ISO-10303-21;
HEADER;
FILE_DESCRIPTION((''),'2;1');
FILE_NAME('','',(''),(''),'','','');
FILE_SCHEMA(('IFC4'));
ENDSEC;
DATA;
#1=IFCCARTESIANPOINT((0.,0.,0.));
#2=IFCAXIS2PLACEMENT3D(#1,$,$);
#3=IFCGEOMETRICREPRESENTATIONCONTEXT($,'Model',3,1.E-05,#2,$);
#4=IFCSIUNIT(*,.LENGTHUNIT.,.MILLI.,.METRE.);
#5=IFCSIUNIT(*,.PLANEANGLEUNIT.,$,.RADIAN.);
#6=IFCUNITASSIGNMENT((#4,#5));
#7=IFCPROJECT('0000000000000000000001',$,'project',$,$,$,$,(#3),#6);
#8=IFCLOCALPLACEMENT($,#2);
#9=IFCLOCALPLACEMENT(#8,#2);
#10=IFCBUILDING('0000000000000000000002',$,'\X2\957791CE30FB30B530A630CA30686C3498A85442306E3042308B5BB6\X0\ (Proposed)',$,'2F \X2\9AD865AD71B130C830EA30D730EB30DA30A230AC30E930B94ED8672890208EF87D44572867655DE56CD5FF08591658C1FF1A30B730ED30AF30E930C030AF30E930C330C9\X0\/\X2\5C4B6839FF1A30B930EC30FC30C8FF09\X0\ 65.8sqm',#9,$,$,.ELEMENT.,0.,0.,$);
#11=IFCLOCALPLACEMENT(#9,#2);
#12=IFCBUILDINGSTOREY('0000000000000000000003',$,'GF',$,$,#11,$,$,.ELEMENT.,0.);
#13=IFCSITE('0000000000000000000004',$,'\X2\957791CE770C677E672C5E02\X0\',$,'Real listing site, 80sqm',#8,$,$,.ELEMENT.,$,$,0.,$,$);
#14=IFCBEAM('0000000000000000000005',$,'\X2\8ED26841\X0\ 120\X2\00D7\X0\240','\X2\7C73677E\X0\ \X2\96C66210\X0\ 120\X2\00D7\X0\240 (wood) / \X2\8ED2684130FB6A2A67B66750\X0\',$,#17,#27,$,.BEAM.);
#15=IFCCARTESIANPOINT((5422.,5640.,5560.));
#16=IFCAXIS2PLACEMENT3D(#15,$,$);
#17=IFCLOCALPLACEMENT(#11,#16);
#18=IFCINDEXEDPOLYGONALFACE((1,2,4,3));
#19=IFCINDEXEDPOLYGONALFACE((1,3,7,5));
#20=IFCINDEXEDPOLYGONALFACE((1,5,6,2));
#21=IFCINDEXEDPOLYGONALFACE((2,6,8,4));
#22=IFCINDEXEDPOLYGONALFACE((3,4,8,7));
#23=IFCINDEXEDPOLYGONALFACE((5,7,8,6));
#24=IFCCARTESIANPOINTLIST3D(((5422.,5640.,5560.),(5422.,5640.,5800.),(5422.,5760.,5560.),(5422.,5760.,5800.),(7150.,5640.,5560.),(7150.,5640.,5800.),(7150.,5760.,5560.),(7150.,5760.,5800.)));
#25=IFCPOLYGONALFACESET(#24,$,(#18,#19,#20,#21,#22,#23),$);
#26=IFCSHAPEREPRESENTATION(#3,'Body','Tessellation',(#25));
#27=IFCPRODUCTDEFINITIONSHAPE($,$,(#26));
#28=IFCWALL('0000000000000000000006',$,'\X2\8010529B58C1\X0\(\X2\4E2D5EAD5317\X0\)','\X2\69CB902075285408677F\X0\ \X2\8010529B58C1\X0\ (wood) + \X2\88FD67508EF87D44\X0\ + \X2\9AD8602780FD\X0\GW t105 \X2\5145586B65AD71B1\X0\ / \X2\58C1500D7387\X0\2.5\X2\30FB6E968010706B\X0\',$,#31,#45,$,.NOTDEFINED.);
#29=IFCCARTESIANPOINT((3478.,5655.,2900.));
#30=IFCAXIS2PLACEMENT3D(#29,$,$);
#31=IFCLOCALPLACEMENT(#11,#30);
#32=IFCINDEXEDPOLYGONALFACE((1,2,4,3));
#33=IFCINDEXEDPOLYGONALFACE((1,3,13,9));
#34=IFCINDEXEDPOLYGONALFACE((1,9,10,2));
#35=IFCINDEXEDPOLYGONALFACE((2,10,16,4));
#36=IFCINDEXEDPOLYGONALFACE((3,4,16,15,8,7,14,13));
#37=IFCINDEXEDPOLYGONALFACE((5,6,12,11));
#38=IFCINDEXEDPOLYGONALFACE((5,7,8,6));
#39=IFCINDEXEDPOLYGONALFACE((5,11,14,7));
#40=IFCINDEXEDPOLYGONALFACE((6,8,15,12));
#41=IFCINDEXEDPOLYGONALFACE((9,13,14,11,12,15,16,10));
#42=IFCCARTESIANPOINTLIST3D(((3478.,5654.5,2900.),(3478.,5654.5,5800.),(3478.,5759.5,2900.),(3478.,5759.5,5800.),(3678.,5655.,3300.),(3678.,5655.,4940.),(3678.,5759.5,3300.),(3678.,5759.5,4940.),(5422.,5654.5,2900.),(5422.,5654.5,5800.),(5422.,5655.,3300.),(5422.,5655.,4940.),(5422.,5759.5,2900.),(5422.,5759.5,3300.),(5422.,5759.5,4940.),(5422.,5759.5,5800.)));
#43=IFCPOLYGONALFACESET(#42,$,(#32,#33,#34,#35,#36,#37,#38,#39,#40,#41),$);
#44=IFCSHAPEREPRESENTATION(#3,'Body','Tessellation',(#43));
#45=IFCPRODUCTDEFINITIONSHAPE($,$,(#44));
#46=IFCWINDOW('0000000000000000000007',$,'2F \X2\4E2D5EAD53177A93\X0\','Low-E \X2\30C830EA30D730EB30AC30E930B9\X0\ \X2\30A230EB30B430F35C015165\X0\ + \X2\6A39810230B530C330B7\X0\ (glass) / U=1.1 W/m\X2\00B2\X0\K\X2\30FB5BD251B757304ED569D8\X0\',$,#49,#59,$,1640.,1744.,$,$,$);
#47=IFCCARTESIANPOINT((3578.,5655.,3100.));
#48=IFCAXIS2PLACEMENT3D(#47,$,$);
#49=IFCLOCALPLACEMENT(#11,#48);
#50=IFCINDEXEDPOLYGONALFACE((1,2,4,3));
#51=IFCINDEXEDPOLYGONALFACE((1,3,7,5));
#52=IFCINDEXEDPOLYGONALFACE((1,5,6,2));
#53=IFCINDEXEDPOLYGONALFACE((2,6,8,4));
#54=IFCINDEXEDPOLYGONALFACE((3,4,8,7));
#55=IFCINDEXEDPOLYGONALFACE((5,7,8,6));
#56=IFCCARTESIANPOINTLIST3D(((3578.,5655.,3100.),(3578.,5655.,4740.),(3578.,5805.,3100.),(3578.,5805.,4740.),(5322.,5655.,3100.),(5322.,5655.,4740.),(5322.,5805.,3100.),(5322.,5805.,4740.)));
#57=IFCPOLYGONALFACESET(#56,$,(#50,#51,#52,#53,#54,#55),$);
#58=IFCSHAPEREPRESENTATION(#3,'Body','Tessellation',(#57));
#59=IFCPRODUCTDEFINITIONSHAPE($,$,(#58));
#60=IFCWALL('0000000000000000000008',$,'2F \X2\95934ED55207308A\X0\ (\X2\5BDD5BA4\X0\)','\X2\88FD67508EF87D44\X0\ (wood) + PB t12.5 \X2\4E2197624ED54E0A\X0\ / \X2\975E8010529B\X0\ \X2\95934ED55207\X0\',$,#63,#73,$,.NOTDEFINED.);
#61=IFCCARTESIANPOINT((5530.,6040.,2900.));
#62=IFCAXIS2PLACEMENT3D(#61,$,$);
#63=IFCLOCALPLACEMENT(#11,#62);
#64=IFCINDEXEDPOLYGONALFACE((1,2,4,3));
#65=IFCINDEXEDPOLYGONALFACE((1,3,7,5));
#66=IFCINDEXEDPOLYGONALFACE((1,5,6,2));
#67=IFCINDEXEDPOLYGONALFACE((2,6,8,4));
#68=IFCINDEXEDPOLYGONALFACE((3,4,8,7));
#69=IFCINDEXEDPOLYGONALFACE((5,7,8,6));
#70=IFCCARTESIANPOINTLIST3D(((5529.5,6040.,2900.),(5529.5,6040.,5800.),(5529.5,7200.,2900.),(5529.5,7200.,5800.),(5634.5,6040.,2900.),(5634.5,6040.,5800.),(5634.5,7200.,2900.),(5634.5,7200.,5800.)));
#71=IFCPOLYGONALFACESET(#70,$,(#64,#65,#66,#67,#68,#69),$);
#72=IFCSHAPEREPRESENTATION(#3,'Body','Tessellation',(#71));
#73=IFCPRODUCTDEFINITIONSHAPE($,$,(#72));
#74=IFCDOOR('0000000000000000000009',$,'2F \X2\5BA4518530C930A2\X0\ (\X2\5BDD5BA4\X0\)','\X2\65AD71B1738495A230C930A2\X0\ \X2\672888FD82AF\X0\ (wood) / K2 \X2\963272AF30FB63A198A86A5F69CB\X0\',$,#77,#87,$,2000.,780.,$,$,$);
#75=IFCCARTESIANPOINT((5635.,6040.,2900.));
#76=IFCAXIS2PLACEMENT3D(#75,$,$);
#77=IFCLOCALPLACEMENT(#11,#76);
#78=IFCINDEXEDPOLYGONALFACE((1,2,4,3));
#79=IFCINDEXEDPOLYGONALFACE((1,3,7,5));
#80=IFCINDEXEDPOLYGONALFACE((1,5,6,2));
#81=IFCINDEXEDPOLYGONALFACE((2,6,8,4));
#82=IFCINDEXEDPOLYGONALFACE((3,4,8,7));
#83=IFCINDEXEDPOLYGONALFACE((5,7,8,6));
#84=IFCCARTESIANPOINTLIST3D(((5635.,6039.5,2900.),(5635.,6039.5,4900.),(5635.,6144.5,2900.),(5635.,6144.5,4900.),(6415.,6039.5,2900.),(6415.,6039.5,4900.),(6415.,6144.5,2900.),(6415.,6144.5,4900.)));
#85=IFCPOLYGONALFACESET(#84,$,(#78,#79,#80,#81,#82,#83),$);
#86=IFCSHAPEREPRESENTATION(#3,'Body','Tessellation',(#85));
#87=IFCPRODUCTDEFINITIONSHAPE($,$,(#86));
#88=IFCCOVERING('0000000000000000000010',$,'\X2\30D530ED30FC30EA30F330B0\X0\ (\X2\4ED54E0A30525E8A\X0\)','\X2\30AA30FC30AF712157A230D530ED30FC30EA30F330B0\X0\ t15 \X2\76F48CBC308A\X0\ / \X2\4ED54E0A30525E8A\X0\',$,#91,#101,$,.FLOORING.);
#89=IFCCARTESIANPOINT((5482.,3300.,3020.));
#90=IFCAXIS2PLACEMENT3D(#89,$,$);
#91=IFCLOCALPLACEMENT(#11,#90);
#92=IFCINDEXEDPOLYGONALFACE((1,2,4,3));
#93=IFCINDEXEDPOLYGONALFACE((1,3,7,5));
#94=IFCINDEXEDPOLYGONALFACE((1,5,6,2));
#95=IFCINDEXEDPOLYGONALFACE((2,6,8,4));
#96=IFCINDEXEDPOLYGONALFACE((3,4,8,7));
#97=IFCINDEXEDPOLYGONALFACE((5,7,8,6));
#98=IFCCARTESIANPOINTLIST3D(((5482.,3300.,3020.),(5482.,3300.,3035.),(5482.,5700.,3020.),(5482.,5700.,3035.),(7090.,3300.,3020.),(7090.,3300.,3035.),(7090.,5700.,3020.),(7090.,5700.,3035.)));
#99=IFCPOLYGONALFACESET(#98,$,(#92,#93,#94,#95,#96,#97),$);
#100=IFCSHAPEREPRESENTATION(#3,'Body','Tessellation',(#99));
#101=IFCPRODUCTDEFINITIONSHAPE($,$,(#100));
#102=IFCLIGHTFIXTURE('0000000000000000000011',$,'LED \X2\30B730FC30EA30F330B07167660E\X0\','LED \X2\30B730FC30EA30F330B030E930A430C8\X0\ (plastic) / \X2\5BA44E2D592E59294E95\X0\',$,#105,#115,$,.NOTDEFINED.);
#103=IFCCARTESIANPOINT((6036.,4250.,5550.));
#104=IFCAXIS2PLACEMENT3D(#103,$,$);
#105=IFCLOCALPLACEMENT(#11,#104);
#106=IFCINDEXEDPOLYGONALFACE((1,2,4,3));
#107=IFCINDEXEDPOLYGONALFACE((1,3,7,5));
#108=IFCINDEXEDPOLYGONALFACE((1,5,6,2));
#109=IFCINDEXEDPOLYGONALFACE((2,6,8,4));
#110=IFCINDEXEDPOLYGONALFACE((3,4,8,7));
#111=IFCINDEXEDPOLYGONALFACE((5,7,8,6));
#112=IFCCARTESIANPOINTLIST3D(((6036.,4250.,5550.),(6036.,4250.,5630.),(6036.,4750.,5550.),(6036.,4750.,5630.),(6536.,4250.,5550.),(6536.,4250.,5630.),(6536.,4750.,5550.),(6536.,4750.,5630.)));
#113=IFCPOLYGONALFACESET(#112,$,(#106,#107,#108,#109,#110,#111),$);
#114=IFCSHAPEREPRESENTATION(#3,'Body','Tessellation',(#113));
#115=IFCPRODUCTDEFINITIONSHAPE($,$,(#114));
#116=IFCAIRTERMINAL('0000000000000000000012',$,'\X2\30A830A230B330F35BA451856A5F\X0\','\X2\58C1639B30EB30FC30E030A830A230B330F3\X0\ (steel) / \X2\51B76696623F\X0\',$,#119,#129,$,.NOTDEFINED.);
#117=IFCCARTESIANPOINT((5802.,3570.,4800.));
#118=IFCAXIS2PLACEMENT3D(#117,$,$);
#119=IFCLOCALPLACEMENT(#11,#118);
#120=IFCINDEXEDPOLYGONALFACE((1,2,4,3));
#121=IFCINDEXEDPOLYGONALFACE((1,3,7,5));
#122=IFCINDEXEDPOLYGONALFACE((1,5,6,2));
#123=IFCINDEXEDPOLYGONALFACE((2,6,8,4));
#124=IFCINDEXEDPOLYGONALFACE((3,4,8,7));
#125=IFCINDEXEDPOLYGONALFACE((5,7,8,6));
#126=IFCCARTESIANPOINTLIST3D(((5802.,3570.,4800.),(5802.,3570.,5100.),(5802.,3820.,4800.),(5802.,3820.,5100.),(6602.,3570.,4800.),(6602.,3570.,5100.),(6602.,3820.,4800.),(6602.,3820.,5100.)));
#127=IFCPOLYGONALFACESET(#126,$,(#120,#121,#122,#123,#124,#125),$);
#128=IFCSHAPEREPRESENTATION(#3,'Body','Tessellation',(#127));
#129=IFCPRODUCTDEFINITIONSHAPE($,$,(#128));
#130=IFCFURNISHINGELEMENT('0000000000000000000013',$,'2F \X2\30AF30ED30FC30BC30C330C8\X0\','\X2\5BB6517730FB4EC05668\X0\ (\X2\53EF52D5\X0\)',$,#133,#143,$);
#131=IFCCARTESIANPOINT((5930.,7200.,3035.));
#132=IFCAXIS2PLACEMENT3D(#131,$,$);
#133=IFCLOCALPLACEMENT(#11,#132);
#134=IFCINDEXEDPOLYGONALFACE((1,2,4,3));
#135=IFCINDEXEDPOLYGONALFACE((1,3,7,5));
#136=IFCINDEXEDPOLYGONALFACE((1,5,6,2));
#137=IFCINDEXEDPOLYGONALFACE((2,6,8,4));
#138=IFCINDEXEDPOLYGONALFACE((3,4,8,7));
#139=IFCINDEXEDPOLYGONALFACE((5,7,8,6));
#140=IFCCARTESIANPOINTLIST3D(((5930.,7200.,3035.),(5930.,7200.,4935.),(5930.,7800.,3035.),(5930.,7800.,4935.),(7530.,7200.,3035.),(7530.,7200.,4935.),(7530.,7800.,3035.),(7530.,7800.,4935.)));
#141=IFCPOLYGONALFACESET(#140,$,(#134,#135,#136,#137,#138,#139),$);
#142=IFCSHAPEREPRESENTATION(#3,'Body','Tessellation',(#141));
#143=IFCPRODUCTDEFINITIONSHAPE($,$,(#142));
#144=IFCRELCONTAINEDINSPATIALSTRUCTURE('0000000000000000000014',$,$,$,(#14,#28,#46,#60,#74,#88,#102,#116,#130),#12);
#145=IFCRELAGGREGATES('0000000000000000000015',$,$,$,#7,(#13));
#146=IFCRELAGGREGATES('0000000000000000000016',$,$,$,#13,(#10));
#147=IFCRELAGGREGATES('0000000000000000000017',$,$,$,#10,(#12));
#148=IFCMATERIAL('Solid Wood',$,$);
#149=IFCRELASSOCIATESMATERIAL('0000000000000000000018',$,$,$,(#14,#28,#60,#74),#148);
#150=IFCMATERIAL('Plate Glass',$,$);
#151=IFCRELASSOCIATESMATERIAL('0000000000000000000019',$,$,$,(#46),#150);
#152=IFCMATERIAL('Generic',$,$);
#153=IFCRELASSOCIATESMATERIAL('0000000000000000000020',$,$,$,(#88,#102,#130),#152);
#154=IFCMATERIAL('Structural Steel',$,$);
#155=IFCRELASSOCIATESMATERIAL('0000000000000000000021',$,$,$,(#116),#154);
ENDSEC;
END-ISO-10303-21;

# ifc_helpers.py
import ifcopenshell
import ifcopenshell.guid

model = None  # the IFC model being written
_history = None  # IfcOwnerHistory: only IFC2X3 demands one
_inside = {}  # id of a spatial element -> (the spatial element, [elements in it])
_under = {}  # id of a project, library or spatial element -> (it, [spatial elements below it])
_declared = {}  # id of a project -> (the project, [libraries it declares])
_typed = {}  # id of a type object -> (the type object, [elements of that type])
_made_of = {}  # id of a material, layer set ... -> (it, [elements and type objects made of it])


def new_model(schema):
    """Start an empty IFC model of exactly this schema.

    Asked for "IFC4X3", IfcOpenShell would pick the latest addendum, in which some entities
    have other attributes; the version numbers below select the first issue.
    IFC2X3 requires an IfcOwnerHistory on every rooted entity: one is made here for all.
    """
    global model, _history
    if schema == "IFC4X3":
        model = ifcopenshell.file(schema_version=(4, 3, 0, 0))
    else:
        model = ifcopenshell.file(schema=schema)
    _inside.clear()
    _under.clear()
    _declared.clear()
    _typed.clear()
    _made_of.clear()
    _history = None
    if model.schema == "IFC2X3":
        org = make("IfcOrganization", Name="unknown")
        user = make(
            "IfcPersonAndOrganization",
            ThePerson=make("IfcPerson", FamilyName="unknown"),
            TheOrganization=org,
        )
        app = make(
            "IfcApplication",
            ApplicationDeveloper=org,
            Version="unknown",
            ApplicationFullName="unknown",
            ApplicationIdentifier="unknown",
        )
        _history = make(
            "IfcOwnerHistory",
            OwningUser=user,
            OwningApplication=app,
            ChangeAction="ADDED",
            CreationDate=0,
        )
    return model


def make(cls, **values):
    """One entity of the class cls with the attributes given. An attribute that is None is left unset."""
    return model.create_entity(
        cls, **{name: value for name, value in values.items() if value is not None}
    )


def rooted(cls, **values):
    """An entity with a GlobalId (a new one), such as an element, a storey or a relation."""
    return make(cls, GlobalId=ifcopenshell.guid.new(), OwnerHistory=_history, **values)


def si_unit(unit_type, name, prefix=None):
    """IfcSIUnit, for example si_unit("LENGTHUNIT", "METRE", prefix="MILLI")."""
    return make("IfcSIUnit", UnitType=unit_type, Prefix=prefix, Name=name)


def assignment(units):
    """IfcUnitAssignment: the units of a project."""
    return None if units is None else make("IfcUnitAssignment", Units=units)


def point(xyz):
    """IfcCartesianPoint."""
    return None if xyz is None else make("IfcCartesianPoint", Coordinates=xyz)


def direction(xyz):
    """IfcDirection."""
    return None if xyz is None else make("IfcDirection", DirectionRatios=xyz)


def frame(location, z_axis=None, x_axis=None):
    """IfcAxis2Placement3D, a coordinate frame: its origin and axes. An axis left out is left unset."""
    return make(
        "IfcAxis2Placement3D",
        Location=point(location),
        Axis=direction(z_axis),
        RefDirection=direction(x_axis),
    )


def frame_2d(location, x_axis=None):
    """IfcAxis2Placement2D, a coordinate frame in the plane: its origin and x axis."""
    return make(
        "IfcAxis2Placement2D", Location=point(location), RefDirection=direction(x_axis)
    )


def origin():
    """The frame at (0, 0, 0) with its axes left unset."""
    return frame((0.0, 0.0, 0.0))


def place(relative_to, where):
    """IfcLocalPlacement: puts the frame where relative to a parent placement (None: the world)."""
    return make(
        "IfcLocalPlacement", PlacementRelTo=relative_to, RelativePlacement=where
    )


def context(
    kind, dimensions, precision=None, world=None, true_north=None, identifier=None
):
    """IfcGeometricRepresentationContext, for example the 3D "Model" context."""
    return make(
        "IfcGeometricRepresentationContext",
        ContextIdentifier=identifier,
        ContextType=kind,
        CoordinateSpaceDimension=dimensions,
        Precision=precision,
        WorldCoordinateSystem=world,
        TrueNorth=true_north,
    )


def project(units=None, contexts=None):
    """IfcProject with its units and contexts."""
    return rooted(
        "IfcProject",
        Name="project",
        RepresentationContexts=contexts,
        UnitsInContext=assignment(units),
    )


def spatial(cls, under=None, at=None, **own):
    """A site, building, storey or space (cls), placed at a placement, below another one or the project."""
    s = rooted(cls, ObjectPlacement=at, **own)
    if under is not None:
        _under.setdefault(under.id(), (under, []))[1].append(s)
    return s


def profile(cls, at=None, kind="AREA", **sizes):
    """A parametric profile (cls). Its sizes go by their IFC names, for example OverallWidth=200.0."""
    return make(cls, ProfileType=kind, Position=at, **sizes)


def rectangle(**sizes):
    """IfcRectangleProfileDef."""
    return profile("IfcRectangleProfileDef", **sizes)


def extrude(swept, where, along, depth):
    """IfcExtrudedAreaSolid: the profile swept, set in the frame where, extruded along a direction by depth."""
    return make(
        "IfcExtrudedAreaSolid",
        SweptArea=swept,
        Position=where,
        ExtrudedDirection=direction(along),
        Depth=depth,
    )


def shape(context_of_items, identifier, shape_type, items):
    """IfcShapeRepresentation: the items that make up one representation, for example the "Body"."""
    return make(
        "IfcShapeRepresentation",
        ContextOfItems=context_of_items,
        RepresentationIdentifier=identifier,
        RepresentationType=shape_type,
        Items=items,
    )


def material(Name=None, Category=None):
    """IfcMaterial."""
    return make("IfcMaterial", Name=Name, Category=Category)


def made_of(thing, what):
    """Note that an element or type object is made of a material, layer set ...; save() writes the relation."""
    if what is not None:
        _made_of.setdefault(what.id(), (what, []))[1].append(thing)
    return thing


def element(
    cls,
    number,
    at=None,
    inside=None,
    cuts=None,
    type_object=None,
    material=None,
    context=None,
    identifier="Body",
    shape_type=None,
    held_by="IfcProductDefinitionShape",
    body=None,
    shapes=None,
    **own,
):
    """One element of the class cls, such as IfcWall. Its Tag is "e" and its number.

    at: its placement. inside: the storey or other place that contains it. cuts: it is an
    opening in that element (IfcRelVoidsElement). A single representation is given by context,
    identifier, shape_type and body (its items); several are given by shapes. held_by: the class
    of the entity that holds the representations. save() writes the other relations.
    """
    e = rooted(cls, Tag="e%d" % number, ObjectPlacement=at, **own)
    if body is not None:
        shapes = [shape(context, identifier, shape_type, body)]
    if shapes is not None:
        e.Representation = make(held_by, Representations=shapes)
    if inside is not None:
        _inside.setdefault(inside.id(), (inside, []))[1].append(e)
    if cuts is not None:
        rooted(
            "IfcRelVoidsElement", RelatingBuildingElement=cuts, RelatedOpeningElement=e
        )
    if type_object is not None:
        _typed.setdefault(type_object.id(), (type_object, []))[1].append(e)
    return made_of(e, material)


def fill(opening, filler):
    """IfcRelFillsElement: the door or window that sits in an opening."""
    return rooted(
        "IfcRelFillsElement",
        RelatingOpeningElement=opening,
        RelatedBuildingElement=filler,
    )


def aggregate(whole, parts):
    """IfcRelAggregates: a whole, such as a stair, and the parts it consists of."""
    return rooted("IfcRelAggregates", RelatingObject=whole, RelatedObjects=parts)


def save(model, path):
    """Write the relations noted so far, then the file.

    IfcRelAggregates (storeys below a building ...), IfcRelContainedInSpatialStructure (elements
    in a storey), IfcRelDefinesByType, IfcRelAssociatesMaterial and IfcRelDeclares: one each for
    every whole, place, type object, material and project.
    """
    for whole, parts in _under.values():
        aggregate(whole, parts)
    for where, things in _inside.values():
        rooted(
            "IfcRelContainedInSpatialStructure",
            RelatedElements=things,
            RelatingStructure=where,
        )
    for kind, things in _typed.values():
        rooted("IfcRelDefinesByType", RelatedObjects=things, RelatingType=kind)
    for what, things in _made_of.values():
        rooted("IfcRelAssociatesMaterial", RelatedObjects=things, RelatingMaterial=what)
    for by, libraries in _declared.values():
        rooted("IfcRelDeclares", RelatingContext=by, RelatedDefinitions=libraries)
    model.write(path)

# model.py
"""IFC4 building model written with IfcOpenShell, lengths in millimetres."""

from ifc_helpers import new_model, si_unit, frame, frame_2d, origin, place, context, project, spatial, rectangle, extrude, material, element, fill, save


model = new_model("IFC4")

# Units and contexts
model_context = context("Model", 3, precision=1e-05, world=origin())
ifc_project = project(units=[si_unit("LENGTHUNIT", "METRE", prefix="MILLI"), si_unit("PLANEANGLEUNIT", "RADIAN")], contexts=[model_context])

# Site, building, storey
site_placement = place(None, origin())
site = spatial("IfcSite", under=ifc_project, at=site_placement, Name="長野県松本市", ObjectType="Real listing site, 80sqm", CompositionType="ELEMENT", RefElevation=0.0)
building_placement = place(site_placement, origin())
building = spatial("IfcBuilding", under=site, at=building_placement, Name="長野・サウナと水風呂のある家 (Proposed)", ObjectType="2F 高断熱トリプルペアガラス付木造軸組在来工法（外壁：シロクラダクラッド/屋根：スレート） 65.8sqm", CompositionType="ELEMENT", ElevationOfRefHeight=0.0, ElevationOfTerrain=0.0)
storey_placement = place(building_placement, origin())
storey = spatial("IfcBuildingStorey", under=building, at=storey_placement, Name="GF", CompositionType="ELEMENT", Elevation=0.0)

# Shared definitions
ifc_material_1 = material(Name="Solid Wood")

# Beam
beam_1_placement = place(storey_placement, frame((5422.0, 5640.0, 5560.0)))
element("IfcBeam", 1, at=beam_1_placement, inside=storey, material=ifc_material_1, Name="軒桁 120×240", Description="米松 集成 120×240 (wood) / 軒桁・横架材", PredefinedType="BEAM", context=model_context, shape_type="SweptSolid", body=[
    extrude(rectangle(XDim=1728.0, YDim=120.0, at=frame_2d((864.0, 60.0))), frame((5422.0, 5640.0, 5560.0)), (0.0, 0.0, 1.0), 240.0),
])

# Wall, opening, window
wall_1_placement = place(storey_placement, frame((3478.0, 5655.0, 2900.0)))
wall_1 = element("IfcWall", 2, at=wall_1_placement, inside=storey, material=ifc_material_1, Name="耐力壁(中庭北)", Description="構造用合板 耐力壁 (wood) + 製材軸組 + 高性能GW t105 充填断熱 / 壁倍率2.5・準耐火", PredefinedType="NOTDEFINED", context=model_context, shape_type="SweptSolid", body=[
    extrude(rectangle(XDim=1944.0, YDim=105.0, at=frame_2d((972.0, 52.0))), frame((3478.0, 5655.0, 2900.0)), (0.0, 0.0, 1.0), 2900.0),
])
opening_placement = place(storey_placement, frame((3578.0, 5655.0, 3100.0)))
opening = element("IfcOpeningElement", 3, at=opening_placement, cuts=wall_1, PredefinedType="NOTDEFINED", context=model_context, shape_type="SweptSolid", body=[
    extrude(rectangle(XDim=1744.0, YDim=150.0, at=frame_2d((872.0, 75.0))), frame((3578.0, 5655.0, 3100.0)), (0.0, 0.0, 1.0), 1640.0),
])
ifc_material_2 = material(Name="Plate Glass")
window_placement = place(storey_placement, frame((3578.0, 5655.0, 3100.0)))
window = element("IfcWindow", 4, at=window_placement, inside=storey, material=ifc_material_2, Name="2F 中庭北窓", Description="Low-E トリプルガラス アルゴン封入 + 樹脂サッシ (glass) / U=1.1 W/m²K・寒冷地仕様", OverallHeight=1640.0, OverallWidth=1744.0, context=model_context, shape_type="SweptSolid", body=[
    extrude(rectangle(XDim=1744.0, YDim=150.0, at=frame_2d((872.0, 75.0))), frame((3578.0, 5655.0, 3100.0)), (0.0, 0.0, 1.0), 1640.0),
])
fill(opening, window)

# Wall
wall_2_placement = place(storey_placement, frame((5530.0, 6040.0, 2900.0)))
element("IfcWall", 5, at=wall_2_placement, inside=storey, material=ifc_material_1, Name="2F 間仕切り (寝室)", Description="製材軸組 (wood) + PB t12.5 両面仕上 / 非耐力 間仕切", PredefinedType="NOTDEFINED", context=model_context, shape_type="SweptSolid", body=[
    extrude(rectangle(XDim=105.0, YDim=1160.0, at=frame_2d((52.0, 580.0))), frame((5530.0, 6040.0, 2900.0)), (0.0, 0.0, 1.0), 2900.0),
])

# Door
door_placement = place(storey_placement, frame((5635.0, 6040.0, 2900.0)))
element("IfcDoor", 6, at=door_placement, inside=storey, material=ifc_material_1, Name="2F 室内ドア (寝室)", Description="断熱玄関ドア 木製芯 (wood) / K2 防犯・採風機構", OverallHeight=2000.0, OverallWidth=780.0, context=model_context, shape_type="SweptSolid", body=[
    extrude(rectangle(XDim=780.0, YDim=105.0, at=frame_2d((390.0, 52.0))), frame((5635.0, 6040.0, 2900.0)), (0.0, 0.0, 1.0), 2000.0),
])

# Covering
ifc_material_3 = material(Name="Generic")
covering_placement = place(storey_placement, frame((5482.0, 3300.0, 3020.0)))
element("IfcCovering", 7, at=covering_placement, inside=storey, material=ifc_material_3, Name="フローリング (仕上げ床)", Description="オーク無垢フローリング t15 直貼り / 仕上げ床", PredefinedType="FLOORING", context=model_context, shape_type="SweptSolid", body=[
    extrude(rectangle(XDim=1608.0, YDim=2400.0, at=frame_2d((804.0, 1200.0))), frame((5482.0, 3300.0, 3020.0)), (0.0, 0.0, 1.0), 15.0),
])

# Light fixture
light_fixture_placement = place(storey_placement, frame((6036.0, 4250.0, 5550.0)))
element("IfcLightFixture", 8, at=light_fixture_placement, inside=storey, material=ifc_material_3, Name="LED シーリング照明", Description="LED シーリングライト (plastic) / 室中央天井", PredefinedType="NOTDEFINED", context=model_context, shape_type="SweptSolid", body=[
    extrude(rectangle(XDim=500.0, YDim=500.0, at=frame_2d((250.0, 250.0))), frame((6036.0, 4250.0, 5550.0)), (0.0, 0.0, 1.0), 80.0),
])

# Air terminal
ifc_material_4 = material(Name="Structural Steel")
air_terminal_placement = place(storey_placement, frame((5802.0, 3570.0, 4800.0)))
element("IfcAirTerminal", 9, at=air_terminal_placement, inside=storey, material=ifc_material_4, Name="エアコン室内機", Description="壁掛ルームエアコン (steel) / 冷暖房", PredefinedType="NOTDEFINED", context=model_context, shape_type="SweptSolid", body=[
    extrude(rectangle(XDim=800.0, YDim=250.0, at=frame_2d((400.0, 125.0))), frame((5802.0, 3570.0, 4800.0)), (0.0, 0.0, 1.0), 300.0),
])

# Furnishing element
furnishing_placement = place(storey_placement, frame((5930.0, 7200.0, 3035.0)))
element("IfcFurnishingElement", 10, at=furnishing_placement, inside=storey, material=ifc_material_3, Name="2F クローゼット", Description="家具・什器 (可動)", context=model_context, shape_type="SweptSolid", body=[
    extrude(rectangle(XDim=1600.0, YDim=600.0, at=frame_2d((800.0, 300.0))), frame((5930.0, 7200.0, 3035.0)), (0.0, 0.0, 1.0), 1900.0),
])

save(model, "model.ifc")
